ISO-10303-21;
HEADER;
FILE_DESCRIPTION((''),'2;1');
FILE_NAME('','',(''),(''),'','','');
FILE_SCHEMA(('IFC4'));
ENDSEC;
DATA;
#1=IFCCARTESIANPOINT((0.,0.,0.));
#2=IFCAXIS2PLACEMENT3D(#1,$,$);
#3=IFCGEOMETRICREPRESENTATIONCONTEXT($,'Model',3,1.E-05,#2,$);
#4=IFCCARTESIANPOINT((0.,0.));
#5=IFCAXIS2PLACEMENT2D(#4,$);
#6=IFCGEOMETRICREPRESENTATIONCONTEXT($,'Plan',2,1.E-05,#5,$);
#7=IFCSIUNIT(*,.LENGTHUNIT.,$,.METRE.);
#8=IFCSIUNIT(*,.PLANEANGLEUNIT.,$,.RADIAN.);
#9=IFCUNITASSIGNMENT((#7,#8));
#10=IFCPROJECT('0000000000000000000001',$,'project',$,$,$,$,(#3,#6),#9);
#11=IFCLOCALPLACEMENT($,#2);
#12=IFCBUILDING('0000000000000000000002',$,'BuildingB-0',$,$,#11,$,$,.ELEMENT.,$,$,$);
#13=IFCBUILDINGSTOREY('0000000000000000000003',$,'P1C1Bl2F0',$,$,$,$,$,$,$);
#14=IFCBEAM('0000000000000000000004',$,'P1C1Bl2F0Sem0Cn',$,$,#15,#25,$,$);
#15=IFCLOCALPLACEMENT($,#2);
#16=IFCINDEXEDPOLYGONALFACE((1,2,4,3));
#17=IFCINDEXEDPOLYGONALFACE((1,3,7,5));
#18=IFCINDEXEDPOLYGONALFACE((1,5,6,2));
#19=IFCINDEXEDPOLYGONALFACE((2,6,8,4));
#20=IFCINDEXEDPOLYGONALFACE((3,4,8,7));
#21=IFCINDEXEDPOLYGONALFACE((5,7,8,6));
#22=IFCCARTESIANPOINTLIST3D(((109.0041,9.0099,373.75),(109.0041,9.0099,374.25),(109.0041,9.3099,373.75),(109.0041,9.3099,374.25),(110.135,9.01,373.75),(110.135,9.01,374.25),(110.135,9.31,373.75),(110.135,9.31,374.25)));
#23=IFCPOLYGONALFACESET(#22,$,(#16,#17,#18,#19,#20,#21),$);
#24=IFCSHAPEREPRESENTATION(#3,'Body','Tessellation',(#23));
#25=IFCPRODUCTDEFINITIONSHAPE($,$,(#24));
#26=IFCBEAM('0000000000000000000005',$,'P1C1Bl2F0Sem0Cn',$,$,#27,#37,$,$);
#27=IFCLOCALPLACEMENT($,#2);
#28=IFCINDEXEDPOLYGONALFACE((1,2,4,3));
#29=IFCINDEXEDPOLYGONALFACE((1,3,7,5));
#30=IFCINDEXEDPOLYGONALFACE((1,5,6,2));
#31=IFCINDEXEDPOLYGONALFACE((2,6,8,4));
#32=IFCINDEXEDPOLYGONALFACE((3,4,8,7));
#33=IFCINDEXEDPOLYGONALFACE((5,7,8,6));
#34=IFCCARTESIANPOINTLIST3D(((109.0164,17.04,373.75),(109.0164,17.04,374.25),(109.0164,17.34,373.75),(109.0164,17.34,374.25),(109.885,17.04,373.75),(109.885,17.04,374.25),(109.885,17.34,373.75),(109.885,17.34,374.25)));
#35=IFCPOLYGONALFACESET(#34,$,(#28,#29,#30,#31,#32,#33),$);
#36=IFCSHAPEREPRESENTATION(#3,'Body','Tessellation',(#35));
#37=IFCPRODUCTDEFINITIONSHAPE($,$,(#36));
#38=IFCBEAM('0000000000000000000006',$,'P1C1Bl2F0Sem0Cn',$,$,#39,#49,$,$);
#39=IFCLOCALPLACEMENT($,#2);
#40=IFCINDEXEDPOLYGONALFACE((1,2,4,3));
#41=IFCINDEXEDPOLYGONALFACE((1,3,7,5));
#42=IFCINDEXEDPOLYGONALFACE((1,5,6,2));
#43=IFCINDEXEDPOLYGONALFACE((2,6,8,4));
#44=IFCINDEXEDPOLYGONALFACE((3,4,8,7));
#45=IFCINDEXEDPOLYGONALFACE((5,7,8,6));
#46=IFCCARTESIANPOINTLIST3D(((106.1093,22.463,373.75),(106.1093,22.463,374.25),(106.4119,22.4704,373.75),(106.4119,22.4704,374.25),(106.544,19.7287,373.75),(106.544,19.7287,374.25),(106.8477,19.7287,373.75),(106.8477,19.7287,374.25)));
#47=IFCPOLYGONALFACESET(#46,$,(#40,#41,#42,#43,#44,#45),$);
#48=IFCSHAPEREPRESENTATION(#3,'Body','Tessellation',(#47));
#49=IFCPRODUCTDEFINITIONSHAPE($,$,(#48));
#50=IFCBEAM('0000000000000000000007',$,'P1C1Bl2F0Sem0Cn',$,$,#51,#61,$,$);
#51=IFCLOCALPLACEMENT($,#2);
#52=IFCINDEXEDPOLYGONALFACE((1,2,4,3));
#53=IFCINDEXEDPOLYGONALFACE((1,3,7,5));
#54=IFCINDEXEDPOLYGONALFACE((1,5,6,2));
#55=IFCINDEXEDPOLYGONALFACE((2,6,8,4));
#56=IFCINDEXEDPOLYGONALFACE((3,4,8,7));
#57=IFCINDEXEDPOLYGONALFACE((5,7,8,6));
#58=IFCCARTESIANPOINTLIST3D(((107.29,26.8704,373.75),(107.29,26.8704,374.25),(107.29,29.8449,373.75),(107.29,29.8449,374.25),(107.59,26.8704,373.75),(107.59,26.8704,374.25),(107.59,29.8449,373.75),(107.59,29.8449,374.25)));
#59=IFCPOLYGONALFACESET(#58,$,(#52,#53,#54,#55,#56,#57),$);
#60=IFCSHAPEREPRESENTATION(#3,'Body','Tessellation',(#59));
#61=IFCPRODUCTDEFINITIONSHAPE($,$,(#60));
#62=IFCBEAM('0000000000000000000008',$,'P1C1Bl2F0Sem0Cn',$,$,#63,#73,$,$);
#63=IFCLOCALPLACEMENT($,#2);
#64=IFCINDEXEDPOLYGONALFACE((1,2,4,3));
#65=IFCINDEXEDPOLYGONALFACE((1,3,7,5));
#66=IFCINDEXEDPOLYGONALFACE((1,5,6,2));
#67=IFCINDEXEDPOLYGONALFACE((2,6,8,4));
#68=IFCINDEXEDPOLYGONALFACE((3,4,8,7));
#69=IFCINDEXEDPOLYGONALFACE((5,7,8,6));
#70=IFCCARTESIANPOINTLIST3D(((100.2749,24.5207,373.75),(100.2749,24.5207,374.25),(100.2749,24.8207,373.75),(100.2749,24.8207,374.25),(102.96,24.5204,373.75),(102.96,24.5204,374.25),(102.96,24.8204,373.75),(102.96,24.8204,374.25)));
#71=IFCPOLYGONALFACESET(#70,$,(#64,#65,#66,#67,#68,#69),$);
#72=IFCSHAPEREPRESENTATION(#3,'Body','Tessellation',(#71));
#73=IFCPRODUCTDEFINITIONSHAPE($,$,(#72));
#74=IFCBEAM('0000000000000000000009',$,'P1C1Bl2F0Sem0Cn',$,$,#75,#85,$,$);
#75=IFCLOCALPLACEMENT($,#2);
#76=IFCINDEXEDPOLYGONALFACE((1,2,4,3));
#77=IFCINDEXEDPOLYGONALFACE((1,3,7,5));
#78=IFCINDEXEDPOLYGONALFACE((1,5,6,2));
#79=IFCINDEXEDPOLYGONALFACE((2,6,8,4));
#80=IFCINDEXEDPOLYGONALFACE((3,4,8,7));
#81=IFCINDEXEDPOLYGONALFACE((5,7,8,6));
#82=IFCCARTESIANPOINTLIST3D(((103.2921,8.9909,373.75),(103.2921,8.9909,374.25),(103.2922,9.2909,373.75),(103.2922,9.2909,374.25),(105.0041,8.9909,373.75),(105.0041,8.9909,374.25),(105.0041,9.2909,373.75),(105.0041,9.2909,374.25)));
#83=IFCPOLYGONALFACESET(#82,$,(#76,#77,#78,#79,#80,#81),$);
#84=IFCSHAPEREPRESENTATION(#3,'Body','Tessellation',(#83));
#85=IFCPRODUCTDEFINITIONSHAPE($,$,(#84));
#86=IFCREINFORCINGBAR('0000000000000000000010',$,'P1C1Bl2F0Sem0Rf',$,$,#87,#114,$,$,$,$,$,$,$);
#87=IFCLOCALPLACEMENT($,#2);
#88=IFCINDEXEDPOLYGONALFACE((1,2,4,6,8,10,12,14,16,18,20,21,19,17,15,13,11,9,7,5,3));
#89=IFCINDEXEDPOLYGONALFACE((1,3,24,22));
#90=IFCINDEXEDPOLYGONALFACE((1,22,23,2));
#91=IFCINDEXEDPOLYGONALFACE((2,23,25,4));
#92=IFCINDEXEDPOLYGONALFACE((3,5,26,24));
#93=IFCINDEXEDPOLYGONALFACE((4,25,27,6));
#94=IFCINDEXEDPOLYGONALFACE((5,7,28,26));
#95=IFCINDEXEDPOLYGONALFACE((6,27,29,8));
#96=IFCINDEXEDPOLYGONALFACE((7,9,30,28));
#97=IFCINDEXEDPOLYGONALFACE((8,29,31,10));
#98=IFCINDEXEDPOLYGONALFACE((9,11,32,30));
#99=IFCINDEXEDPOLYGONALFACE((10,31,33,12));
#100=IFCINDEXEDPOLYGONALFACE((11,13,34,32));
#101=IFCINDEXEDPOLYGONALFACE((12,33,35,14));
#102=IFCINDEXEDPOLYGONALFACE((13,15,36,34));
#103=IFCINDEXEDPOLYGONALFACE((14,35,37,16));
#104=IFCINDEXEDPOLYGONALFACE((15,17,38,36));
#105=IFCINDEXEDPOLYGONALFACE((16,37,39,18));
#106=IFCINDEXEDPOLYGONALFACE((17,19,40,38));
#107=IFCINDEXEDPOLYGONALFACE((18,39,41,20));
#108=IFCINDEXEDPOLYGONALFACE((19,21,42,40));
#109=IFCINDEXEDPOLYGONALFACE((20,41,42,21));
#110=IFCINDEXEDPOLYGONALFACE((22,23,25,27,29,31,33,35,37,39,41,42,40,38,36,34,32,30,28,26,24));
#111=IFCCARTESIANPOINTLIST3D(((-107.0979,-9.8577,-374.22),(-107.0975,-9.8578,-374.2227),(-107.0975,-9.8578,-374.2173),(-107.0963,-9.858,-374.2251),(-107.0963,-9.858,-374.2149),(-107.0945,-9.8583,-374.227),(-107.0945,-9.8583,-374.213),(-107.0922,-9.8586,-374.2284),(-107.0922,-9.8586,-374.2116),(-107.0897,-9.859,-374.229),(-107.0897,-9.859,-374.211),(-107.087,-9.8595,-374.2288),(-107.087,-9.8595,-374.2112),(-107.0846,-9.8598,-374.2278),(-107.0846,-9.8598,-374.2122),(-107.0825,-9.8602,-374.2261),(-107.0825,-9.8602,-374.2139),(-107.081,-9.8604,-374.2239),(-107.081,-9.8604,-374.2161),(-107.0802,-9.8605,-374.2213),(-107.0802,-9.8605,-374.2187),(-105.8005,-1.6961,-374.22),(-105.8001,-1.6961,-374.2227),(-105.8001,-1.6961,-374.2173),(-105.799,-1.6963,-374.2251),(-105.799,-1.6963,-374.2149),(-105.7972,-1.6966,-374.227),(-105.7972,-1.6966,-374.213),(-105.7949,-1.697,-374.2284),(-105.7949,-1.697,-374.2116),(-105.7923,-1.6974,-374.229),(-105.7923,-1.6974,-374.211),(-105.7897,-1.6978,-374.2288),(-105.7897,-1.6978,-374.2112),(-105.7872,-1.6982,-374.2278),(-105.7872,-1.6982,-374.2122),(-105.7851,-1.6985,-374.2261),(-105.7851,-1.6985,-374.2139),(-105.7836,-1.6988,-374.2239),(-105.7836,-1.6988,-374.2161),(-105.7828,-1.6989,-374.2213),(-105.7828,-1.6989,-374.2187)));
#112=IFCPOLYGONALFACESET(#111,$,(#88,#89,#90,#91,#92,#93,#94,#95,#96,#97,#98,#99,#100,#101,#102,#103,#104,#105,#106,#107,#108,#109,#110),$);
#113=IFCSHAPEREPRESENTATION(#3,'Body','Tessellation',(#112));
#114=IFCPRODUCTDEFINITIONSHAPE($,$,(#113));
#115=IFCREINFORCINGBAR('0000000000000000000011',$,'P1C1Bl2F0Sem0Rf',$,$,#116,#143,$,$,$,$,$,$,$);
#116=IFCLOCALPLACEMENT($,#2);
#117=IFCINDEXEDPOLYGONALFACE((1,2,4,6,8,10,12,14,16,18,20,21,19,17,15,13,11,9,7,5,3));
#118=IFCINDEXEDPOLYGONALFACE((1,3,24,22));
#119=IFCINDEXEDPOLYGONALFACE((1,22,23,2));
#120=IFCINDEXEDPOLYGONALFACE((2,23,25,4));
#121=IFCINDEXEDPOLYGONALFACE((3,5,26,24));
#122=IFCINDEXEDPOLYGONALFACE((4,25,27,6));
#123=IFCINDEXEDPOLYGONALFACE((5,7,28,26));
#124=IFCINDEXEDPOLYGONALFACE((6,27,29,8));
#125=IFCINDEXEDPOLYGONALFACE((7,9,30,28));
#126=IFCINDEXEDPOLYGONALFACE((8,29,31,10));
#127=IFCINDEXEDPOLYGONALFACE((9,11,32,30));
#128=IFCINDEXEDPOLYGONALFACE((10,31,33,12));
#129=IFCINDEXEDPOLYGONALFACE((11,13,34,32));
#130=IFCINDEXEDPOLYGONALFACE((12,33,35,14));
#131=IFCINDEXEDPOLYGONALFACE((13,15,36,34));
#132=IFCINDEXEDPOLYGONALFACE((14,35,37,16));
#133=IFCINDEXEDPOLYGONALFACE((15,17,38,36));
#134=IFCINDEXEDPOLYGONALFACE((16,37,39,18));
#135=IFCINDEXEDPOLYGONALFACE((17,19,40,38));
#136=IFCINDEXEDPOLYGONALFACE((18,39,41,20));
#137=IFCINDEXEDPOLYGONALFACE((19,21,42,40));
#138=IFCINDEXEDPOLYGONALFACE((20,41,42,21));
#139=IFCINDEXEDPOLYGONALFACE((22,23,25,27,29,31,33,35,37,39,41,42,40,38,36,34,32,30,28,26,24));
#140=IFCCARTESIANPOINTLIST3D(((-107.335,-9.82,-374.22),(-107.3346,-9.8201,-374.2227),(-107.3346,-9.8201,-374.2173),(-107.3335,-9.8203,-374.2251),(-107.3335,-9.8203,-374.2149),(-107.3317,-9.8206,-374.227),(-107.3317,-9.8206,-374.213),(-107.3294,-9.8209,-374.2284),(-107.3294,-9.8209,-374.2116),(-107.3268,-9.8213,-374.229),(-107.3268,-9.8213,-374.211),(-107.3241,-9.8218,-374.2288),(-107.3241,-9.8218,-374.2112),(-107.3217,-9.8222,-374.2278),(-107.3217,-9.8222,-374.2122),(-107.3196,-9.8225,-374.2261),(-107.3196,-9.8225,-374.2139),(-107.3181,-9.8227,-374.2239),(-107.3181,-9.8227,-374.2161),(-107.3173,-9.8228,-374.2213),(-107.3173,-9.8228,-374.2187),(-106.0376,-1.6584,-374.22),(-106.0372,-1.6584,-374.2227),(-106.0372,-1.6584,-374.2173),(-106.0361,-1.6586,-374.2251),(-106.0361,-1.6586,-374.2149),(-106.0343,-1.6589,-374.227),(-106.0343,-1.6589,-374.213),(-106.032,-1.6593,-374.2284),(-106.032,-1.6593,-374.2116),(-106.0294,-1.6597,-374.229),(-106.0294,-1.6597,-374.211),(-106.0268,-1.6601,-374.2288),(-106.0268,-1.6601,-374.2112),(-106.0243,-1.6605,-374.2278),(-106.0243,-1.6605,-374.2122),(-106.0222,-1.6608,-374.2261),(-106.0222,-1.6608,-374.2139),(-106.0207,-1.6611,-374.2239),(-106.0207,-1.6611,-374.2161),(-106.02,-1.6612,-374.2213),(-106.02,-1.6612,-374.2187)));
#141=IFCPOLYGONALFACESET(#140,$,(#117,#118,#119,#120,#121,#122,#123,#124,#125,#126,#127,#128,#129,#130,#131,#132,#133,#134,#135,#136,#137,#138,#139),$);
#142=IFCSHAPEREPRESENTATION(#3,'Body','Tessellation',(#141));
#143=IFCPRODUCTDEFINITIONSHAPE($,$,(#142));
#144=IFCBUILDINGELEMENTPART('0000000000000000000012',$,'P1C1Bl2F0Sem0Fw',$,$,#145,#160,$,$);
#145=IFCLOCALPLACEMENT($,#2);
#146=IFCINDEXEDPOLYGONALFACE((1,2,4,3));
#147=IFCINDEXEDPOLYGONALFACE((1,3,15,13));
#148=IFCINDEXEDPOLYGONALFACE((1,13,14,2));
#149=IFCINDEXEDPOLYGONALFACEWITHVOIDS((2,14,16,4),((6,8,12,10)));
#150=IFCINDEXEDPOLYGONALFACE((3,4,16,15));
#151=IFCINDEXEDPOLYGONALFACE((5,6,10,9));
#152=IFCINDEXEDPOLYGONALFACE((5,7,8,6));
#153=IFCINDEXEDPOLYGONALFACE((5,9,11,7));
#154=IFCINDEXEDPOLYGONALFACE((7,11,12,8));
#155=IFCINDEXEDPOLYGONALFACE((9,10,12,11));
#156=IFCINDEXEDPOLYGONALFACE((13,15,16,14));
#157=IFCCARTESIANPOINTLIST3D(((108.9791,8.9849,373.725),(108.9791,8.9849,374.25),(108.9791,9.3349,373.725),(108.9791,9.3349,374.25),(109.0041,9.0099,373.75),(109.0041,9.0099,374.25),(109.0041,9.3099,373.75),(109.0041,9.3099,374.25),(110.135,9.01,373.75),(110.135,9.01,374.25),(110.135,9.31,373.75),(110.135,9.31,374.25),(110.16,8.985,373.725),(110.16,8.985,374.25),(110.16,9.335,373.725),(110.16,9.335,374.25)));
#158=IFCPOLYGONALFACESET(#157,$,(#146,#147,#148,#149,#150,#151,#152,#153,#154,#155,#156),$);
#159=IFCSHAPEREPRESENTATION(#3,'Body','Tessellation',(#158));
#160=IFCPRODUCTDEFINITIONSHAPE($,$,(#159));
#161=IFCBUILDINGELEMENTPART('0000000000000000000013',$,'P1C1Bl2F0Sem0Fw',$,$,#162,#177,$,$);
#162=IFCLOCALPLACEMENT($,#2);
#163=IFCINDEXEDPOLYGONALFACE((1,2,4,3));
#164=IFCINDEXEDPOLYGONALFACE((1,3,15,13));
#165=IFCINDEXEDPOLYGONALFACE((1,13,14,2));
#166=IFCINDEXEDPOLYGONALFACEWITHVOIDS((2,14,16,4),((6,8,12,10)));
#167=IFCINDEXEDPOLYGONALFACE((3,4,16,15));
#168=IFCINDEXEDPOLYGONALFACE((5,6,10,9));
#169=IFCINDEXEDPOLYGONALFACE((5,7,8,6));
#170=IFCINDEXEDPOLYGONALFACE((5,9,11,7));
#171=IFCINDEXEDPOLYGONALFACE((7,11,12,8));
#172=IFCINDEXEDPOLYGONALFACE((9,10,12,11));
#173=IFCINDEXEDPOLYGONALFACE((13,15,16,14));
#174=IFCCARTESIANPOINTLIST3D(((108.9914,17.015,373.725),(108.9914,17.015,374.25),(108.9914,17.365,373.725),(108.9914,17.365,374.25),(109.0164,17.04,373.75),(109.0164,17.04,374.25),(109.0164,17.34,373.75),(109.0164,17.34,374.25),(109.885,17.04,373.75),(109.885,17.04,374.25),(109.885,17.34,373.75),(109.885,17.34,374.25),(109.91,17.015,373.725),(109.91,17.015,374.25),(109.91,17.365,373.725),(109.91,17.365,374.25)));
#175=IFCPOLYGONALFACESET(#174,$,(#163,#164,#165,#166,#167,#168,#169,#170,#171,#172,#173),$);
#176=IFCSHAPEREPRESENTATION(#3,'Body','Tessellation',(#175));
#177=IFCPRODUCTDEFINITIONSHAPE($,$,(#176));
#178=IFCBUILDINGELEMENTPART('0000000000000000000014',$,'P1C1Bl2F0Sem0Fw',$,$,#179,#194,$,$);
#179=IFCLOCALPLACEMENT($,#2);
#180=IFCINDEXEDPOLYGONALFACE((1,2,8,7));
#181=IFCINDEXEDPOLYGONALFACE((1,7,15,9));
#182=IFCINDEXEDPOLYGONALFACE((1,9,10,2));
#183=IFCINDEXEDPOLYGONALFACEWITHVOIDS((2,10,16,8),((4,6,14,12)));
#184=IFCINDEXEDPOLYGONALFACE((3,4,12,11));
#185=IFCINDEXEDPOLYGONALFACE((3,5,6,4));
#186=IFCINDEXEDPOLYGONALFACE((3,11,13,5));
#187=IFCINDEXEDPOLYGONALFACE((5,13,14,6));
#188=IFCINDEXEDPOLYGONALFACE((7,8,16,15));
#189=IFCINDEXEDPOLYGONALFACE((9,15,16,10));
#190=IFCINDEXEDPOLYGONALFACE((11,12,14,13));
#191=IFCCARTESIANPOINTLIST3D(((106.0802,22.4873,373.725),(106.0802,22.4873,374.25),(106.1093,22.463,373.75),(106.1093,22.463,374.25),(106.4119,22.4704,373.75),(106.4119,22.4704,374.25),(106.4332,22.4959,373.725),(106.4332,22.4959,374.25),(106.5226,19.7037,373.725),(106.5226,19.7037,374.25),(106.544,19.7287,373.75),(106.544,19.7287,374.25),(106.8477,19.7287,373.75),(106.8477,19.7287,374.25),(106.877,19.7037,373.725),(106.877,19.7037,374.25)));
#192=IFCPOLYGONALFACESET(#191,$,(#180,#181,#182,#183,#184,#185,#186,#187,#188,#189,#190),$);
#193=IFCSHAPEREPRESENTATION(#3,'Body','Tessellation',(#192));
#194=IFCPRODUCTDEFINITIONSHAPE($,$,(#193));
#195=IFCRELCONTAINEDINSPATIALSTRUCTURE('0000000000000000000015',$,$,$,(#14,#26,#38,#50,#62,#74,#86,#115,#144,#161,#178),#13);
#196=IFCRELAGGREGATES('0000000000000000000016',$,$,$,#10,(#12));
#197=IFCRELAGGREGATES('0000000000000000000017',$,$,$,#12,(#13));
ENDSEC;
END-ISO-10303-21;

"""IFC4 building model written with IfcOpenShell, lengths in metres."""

from ifc_helpers import new_model, entity, si_unit, origin, origin_2d, place, context, project, spatial, polyline, outline, extrude, element, save


model = new_model("IFC4")

# Units and contexts
model_context = context("Model", 3, precision=1e-05, world=origin())
plan_context = context("Plan", 2, precision=1e-05, world=origin_2d())
ifc_project = project(units=[si_unit("LENGTHUNIT", "METRE"), si_unit("PLANEANGLEUNIT", "RADIAN")], contexts=[model_context, plan_context])

# Building, storey
building_placement = place(None, origin())
building = spatial("IfcBuilding", under=ifc_project, at=building_placement, Name="BuildingB-0", CompositionType="ELEMENT")
storey = spatial("IfcBuildingStorey", under=building, Name="P1C1Bl2F0")

# Beams
element("IfcBeam", 1, inside=storey, Name="P1C1Bl2F0Sem0Cn", context=model_context, shape_type="SweptSolid", body=[
    extrude(outline(polyline([(110.135, 9.01, 373.75), (110.135, 9.31, 373.75), (109.0041, 9.3099, 373.75), (109.0041, 9.0099, 373.75), (110.135, 9.01, 373.75)])), None, (0.0, 0.0, 1.0), 0.5),
])
element("IfcBeam", 2, inside=storey, Name="P1C1Bl2F0Sem0Cn", context=model_context, shape_type="SweptSolid", body=[
    extrude(outline(polyline([(109.885, 17.04, 373.75), (109.885, 17.34, 373.75), (109.0164, 17.34, 373.75), (109.0164, 17.04, 373.75), (109.885, 17.04, 373.75)])), None, (0.0, 0.0, 1.0), 0.5),
])
element("IfcBeam", 3, inside=storey, Name="P1C1Bl2F0Sem0Cn", context=model_context, shape_type="SweptSolid", body=[
    extrude(outline(polyline([(106.544, 19.7287, 373.75), (106.8477, 19.7287, 373.75), (106.4119, 22.4704, 373.75), (106.1093, 22.463, 373.75), (106.544, 19.7287, 373.75)])), None, (0.0, 0.0, 1.0), 0.5),
])
element("IfcBeam", 4, inside=storey, Name="P1C1Bl2F0Sem0Cn", context=model_context, shape_type="SweptSolid", body=[
    extrude(outline(polyline([(107.29, 26.8704, 373.75), (107.59, 26.8704, 373.75), (107.59, 29.8449, 373.75), (107.29, 29.8449, 373.75), (107.29, 26.8704, 373.75)])), None, (0.0, 0.0, 1.0), 0.5),
])
element("IfcBeam", 5, inside=storey, Name="P1C1Bl2F0Sem0Cn", context=model_context, shape_type="SweptSolid", body=[
    extrude(outline(polyline([(102.96, 24.5204, 373.75), (102.96, 24.8204, 373.75), (100.2749, 24.8207, 373.75), (100.2749, 24.5207, 373.75), (102.96, 24.5204, 373.75)])), None, (0.0, 0.0, 1.0), 0.5),
])
element("IfcBeam", 6, inside=storey, Name="P1C1Bl2F0Sem0Cn", context=model_context, shape_type="SweptSolid", body=[
    extrude(outline(polyline([(105.0041, 8.9909, 373.75), (105.0041, 9.2909, 373.75), (103.2922, 9.2909, 373.75), (103.2921, 8.9909, 373.75), (105.0041, 8.9909, 373.75)])), None, (0.0, 0.0, 1.0), 0.5),
])

# Reinforcing bars
element("IfcReinforcingBar", 7, inside=storey, Name="P1C1Bl2F0Sem0Rf", context=model_context, shape_type="SweptSolid", body=[
    entity("IfcSurfaceCurveSweptAreaSolid", entity("IfcCircleProfileDef", "AREA", None, None, 0.009), None, entity("IfcPolyline", [entity("IfcCartesianPoint", [107.089, 9.8591, 374.22]), entity("IfcCartesianPoint", [105.7916, 1.6975, 374.22])]), None, None, entity("IfcPlane", entity("IfcAxis2Placement3D", entity("IfcCartesianPoint", [107.089, 9.8591, 374.22]), entity("IfcDirection", [0.0, 0.0, 1.0]), entity("IfcDirection", [1.0, 0.0, 0.0])))),
])
element("IfcReinforcingBar", 8, inside=storey, Name="P1C1Bl2F0Sem0Rf", context=model_context, shape_type="SweptSolid", body=[
    entity("IfcSurfaceCurveSweptAreaSolid", entity("IfcCircleProfileDef", "AREA", None, None, 0.009), None, entity("IfcPolyline", [entity("IfcCartesianPoint", [107.3261, 9.8214, 374.22]), entity("IfcCartesianPoint", [106.0288, 1.6598, 374.22])]), None, None, entity("IfcPlane", entity("IfcAxis2Placement3D", entity("IfcCartesianPoint", [107.3261, 9.8214, 374.22]), entity("IfcDirection", [0.0, 0.0, 1.0]), entity("IfcDirection", [1.0, 0.0, 0.0])))),
])

# Building element parts, openings
building_element_part_1 = element("IfcBuildingElementPart", 9, inside=storey, Name="P1C1Bl2F0Sem0Fw", context=model_context, shape_type="SweptSolid", body=[
    extrude(outline(polyline([(110.16, 8.985, 373.725), (110.16, 9.335, 373.725), (108.9791, 9.3349, 373.725), (108.9791, 8.9849, 373.725), (110.16, 8.985, 373.725)])), None, (0.0, 0.0, 1.0), 0.525),
])
element("IfcOpeningElement", 10, inside=storey, cuts=building_element_part_1, context=model_context, shape_type="SweptSolid", body=[
    extrude(outline(polyline([(110.135, 9.01, 373.75), (110.135, 9.31, 373.75), (109.0041, 9.3099, 373.75), (109.0041, 9.0099, 373.75), (110.135, 9.01, 373.75)])), None, (0.0, 0.0, 1.0), 0.5),
])
building_element_part_2 = element("IfcBuildingElementPart", 11, inside=storey, Name="P1C1Bl2F0Sem0Fw", context=model_context, shape_type="SweptSolid", body=[
    extrude(outline(polyline([(109.91, 17.015, 373.725), (109.91, 17.365, 373.725), (108.9914, 17.365, 373.725), (108.9914, 17.015, 373.725), (109.91, 17.015, 373.725)])), None, (0.0, 0.0, 1.0), 0.525),
])
element("IfcOpeningElement", 12, inside=storey, cuts=building_element_part_2, context=model_context, shape_type="SweptSolid", body=[
    extrude(outline(polyline([(109.885, 17.04, 373.75), (109.885, 17.34, 373.75), (109.0164, 17.34, 373.75), (109.0164, 17.04, 373.75), (109.885, 17.04, 373.75)])), None, (0.0, 0.0, 1.0), 0.5),
])
building_element_part_3 = element("IfcBuildingElementPart", 13, inside=storey, Name="P1C1Bl2F0Sem0Fw", context=model_context, shape_type="SweptSolid", body=[
    extrude(outline(polyline([(106.5226, 19.7037, 373.725), (106.877, 19.7037, 373.725), (106.4332, 22.4959, 373.725), (106.0802, 22.4873, 373.725), (106.5226, 19.7037, 373.725)])), None, (0.0, 0.0, 1.0), 0.525),
])
element("IfcOpeningElement", 14, inside=storey, cuts=building_element_part_3, context=model_context, shape_type="SweptSolid", body=[
    extrude(outline(polyline([(106.544, 19.7287, 373.75), (106.8477, 19.7287, 373.75), (106.4119, 22.4704, 373.75), (106.1093, 22.463, 373.75), (106.544, 19.7287, 373.75)])), None, (0.0, 0.0, 1.0), 0.5),
])

save(model, "model.ifc")
